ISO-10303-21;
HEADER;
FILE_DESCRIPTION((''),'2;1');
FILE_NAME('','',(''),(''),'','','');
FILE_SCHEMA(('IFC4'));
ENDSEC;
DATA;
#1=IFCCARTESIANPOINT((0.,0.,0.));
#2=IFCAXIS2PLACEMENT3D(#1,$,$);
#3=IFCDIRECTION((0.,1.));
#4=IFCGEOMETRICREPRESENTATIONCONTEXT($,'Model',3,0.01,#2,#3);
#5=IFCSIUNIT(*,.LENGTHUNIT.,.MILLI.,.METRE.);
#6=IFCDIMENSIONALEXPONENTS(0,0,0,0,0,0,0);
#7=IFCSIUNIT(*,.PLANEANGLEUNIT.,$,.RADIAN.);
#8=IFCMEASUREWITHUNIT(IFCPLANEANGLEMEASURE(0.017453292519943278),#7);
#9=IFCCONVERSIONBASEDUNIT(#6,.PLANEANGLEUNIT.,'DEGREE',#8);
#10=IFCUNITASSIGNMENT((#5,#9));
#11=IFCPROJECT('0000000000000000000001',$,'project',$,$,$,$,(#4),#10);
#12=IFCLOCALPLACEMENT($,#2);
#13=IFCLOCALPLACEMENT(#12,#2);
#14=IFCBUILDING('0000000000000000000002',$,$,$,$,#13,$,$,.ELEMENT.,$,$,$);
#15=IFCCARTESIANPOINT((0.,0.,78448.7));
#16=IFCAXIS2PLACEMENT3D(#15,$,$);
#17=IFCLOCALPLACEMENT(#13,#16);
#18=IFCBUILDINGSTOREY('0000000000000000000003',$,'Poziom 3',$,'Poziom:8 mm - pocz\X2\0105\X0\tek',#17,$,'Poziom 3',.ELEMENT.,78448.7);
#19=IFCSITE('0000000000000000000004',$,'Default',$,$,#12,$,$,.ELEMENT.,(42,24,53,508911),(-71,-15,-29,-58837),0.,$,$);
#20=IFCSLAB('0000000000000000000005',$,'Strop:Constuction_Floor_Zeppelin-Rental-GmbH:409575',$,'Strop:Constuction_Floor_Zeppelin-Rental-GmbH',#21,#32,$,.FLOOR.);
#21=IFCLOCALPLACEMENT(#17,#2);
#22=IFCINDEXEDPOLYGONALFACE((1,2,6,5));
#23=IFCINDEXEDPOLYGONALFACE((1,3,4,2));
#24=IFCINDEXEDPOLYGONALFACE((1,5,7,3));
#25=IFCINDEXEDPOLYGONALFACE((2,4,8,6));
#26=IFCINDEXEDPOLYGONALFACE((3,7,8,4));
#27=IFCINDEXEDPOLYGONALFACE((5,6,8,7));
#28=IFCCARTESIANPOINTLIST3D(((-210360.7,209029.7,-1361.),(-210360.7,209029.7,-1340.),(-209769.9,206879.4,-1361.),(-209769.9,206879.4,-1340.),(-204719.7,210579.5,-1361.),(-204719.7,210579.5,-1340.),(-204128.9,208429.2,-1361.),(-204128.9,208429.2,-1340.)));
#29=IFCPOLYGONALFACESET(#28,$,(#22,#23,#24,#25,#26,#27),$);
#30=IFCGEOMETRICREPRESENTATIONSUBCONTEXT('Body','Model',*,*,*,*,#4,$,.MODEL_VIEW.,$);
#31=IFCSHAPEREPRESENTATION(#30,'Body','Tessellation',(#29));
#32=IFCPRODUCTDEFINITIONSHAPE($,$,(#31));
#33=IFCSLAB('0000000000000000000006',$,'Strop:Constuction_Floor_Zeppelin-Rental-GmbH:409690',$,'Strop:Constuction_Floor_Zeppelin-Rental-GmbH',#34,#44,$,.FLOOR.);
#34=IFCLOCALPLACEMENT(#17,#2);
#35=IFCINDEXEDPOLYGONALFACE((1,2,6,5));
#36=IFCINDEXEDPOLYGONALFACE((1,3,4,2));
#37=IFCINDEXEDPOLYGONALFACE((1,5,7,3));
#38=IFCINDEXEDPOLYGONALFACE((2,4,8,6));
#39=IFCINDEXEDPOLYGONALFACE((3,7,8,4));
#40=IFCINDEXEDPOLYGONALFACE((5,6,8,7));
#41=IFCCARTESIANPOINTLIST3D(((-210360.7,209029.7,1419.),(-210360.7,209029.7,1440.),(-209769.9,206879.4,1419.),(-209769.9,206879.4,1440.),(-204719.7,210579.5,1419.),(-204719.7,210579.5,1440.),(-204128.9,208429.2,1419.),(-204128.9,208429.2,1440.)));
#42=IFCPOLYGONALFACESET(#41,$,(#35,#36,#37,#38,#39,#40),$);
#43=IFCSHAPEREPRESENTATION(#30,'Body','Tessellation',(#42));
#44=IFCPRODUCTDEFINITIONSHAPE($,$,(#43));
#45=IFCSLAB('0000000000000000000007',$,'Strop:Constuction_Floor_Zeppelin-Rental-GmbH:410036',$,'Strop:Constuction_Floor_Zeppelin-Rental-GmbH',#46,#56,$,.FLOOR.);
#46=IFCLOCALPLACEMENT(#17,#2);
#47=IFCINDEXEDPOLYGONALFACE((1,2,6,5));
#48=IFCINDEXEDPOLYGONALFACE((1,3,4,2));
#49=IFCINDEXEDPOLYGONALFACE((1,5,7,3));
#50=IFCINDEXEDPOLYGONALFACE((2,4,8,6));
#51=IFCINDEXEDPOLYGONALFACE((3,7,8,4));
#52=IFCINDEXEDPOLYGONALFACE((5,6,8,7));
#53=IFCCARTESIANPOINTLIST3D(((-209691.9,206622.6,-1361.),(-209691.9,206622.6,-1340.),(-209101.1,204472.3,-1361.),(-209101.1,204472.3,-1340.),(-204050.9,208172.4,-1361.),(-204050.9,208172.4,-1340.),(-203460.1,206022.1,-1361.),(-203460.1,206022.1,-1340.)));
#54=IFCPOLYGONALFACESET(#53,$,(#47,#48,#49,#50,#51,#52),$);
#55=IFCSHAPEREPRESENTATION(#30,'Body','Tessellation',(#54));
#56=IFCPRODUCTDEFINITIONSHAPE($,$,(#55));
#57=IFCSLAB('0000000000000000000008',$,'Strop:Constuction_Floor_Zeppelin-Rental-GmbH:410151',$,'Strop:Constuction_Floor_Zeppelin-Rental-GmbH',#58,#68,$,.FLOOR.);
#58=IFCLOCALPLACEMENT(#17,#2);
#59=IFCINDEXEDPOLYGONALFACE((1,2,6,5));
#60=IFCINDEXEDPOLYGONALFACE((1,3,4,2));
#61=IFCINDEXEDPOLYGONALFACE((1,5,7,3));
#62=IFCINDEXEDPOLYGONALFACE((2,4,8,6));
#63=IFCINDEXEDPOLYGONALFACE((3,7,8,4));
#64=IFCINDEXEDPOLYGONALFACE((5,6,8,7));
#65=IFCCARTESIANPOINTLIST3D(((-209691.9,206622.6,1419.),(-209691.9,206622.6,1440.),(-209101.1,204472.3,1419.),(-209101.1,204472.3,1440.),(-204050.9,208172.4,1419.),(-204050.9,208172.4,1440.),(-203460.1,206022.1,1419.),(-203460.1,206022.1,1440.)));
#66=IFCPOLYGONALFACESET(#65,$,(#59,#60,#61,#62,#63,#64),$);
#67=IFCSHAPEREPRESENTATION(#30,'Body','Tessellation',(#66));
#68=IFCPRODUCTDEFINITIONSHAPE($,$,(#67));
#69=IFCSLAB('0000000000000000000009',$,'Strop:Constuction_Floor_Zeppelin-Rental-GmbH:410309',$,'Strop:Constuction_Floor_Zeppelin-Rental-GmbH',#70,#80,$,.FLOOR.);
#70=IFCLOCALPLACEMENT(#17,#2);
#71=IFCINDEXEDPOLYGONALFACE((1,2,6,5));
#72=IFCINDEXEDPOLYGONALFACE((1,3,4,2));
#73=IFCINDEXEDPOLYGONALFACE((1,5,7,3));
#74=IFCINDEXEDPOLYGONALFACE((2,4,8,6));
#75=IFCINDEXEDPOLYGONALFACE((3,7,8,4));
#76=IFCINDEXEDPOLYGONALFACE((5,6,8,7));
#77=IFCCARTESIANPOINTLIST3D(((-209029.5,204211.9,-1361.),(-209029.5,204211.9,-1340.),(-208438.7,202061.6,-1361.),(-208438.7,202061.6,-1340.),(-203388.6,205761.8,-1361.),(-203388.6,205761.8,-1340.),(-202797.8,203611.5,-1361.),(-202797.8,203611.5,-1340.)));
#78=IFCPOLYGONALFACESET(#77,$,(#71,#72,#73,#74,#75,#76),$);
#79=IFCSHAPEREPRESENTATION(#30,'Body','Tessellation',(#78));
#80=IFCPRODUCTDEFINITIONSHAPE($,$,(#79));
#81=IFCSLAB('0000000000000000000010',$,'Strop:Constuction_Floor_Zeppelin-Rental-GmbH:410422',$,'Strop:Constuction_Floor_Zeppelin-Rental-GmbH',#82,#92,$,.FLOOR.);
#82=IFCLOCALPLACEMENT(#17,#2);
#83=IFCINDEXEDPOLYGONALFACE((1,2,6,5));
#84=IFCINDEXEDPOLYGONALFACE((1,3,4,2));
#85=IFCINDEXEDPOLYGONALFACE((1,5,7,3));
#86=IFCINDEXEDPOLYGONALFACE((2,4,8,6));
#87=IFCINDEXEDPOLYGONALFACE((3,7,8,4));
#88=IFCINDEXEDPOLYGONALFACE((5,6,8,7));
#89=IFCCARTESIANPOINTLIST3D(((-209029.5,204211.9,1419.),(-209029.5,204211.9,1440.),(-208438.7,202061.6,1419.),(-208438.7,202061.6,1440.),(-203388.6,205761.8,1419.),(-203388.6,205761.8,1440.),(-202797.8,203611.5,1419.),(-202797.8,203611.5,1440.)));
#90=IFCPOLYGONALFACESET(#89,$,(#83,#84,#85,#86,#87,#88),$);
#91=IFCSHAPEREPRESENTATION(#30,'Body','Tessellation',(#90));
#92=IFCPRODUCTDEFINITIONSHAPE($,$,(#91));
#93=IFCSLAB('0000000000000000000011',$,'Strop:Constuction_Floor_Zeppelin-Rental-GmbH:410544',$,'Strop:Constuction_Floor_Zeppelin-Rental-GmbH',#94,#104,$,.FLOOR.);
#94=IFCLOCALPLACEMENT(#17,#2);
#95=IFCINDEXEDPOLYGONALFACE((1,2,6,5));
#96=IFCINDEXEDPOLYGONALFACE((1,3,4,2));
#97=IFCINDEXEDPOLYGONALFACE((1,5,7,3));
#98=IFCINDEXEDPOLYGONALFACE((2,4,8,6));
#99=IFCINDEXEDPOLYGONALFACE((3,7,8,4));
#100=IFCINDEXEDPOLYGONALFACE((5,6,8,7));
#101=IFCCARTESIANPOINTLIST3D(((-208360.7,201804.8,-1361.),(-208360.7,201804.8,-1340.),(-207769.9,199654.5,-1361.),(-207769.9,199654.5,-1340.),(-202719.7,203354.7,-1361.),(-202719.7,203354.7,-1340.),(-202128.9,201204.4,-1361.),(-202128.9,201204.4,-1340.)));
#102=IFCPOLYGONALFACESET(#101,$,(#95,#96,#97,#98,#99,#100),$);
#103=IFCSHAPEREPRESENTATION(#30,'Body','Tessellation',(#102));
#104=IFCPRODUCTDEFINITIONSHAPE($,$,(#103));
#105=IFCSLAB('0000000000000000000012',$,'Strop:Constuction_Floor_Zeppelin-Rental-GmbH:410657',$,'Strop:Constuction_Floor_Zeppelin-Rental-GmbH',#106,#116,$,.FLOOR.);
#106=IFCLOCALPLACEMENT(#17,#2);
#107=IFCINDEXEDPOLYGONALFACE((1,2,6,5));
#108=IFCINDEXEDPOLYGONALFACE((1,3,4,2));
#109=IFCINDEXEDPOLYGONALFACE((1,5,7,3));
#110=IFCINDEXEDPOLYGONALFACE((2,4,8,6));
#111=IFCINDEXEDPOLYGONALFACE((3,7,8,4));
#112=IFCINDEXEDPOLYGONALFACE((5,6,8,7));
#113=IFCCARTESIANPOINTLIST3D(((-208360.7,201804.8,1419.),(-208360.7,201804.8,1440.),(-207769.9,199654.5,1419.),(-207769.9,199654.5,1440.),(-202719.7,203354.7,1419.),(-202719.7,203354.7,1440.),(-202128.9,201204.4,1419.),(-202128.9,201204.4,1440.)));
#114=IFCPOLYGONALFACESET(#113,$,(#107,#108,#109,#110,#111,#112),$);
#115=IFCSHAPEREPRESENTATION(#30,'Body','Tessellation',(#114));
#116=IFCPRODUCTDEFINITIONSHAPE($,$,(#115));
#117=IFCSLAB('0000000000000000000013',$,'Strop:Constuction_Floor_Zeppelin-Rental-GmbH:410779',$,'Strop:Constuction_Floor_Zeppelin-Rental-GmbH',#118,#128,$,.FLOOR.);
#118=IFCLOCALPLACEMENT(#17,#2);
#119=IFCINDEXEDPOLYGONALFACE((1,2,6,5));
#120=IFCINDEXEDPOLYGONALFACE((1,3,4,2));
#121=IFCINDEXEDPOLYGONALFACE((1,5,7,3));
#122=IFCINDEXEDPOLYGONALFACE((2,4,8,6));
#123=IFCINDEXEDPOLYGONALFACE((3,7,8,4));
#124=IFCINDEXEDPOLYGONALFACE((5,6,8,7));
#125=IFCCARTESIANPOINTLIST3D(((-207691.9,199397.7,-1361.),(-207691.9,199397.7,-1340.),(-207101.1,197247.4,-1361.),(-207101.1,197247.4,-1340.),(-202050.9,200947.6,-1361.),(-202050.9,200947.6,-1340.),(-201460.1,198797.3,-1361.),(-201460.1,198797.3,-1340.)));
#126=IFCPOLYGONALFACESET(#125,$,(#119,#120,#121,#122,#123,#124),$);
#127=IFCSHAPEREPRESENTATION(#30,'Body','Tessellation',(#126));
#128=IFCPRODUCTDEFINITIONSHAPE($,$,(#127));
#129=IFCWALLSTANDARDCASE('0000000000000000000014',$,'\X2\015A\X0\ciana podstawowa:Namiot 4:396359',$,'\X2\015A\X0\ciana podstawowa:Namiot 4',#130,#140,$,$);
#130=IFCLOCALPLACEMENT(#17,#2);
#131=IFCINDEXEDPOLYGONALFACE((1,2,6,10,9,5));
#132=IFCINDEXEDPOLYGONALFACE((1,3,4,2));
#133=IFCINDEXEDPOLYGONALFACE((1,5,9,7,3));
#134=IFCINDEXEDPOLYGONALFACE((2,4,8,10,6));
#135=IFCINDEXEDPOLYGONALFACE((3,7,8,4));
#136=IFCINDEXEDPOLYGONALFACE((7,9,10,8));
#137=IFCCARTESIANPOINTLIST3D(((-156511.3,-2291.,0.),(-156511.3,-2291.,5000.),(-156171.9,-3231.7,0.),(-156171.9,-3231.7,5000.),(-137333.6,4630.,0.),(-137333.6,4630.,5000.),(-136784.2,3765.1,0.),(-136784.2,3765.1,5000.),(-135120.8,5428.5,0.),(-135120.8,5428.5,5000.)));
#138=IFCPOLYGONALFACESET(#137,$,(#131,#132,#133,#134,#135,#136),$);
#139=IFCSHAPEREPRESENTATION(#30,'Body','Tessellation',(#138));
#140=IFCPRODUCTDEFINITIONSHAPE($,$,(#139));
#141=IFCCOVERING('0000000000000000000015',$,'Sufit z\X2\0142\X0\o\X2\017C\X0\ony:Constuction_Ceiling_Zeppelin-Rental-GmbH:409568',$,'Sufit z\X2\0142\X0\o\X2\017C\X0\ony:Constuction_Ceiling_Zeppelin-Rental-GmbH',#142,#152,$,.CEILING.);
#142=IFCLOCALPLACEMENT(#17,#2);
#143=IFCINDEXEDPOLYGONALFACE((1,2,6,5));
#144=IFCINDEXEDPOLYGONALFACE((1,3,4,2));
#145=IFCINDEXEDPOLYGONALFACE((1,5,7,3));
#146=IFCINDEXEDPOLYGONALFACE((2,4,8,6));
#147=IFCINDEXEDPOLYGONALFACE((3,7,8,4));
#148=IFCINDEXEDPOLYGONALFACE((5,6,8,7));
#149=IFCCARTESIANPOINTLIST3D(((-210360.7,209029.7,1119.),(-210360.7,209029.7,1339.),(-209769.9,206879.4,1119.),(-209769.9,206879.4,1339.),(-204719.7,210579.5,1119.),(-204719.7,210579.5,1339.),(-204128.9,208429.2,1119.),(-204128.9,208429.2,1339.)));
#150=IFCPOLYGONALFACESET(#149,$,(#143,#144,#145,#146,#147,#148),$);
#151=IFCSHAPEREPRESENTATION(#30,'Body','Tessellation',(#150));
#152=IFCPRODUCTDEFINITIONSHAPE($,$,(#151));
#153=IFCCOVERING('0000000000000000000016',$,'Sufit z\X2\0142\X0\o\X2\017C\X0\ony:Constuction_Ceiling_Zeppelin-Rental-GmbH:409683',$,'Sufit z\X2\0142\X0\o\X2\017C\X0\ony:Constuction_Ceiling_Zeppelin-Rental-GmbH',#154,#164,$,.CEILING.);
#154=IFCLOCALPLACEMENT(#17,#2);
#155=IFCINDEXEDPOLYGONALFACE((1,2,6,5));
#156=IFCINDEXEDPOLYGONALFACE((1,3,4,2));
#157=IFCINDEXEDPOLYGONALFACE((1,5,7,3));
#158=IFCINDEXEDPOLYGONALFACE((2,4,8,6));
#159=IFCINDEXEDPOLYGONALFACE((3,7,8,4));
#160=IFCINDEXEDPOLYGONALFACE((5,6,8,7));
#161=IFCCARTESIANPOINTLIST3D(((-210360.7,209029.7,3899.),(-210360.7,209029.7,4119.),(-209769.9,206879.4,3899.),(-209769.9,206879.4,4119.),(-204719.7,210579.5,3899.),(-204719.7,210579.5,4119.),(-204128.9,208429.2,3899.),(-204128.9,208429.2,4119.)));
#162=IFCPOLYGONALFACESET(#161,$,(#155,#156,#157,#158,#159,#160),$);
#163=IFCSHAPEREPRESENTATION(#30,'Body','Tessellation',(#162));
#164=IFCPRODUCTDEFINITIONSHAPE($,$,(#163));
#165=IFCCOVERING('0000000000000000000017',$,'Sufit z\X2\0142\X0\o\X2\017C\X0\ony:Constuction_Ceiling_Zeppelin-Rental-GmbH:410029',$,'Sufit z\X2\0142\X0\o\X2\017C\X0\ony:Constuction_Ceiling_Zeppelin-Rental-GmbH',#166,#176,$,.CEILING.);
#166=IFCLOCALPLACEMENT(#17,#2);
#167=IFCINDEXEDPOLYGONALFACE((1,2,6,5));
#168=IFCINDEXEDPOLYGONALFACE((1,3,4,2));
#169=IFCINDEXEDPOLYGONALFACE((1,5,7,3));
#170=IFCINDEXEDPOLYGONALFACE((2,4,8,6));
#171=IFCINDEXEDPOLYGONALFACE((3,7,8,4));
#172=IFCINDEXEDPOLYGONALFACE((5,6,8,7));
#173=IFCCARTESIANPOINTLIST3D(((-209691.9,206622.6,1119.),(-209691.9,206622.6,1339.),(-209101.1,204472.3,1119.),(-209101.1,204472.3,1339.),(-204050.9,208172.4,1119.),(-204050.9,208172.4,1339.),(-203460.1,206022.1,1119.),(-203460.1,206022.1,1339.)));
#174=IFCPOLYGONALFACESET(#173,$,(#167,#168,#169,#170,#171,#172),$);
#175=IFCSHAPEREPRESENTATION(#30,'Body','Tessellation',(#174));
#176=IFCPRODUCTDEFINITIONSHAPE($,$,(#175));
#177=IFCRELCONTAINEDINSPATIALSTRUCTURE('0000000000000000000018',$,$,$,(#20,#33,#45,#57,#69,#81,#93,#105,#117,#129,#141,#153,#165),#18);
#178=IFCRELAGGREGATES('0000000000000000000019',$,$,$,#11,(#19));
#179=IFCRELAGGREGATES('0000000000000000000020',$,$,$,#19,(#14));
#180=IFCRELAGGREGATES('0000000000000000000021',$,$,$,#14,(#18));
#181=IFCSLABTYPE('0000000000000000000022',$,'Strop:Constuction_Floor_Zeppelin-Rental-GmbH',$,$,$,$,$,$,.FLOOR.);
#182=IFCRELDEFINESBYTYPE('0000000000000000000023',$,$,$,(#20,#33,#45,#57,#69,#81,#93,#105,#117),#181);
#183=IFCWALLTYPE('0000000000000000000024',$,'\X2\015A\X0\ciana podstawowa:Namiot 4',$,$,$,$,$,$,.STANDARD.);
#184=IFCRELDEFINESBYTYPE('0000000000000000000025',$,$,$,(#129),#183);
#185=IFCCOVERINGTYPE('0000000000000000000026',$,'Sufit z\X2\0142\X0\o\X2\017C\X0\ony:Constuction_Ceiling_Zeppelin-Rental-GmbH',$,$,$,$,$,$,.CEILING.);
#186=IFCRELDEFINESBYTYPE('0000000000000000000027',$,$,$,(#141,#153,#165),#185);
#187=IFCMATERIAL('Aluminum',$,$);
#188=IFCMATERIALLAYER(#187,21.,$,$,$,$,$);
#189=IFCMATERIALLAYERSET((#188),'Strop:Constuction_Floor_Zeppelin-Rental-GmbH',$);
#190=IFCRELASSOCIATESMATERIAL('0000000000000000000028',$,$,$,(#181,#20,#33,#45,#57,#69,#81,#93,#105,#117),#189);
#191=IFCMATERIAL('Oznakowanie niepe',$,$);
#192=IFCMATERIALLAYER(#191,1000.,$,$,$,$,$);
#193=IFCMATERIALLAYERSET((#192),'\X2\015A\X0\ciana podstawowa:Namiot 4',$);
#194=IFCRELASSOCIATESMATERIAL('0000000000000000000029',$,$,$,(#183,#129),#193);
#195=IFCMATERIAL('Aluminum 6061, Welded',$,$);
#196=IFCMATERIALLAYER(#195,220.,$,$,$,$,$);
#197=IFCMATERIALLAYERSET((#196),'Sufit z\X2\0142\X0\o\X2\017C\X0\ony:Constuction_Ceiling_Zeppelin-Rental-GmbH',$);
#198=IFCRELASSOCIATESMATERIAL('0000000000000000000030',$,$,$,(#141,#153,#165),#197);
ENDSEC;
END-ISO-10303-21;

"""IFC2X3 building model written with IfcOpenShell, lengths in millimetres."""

from ifc_helpers import new_model, entity, si_unit, converted_unit, direction, frame, frame_2d, origin, place, context, subcontext, project, spatial, polyline, rectangle, outline, extrude, material, layer, layer_set, layer_usage, type_object, element, save


model = new_model("IFC2X3")

# Units and contexts
model_context = context("Model", 3, precision=0.01, world=origin(), true_north=direction((0.0, 1.0)))
body_context = subcontext(model_context, "Body", "Model", "MODEL_VIEW")
ifc_project = project(units=[si_unit("LENGTHUNIT", "METRE", prefix="MILLI"), converted_unit("PLANEANGLEUNIT", "DEGREE", entity("IfcPlaneAngleMeasure", 0.017453292519943278), si_unit("PLANEANGLEUNIT", "RADIAN"), dimensions=[0, 0, 0, 0, 0, 0, 0])], contexts=[model_context])

# Site, building, storey
site_placement = place(None, origin())
site = spatial("IfcSite", under=ifc_project, at=site_placement, Name="Default", CompositionType="ELEMENT", RefLatitude=(42, 24, 53, 508911), RefLongitude=(-71, -15, -29, -58837), RefElevation=0.0)
building_placement = place(site_placement, origin())
building = spatial("IfcBuilding", under=site, at=building_placement, CompositionType="ELEMENT")
storey_placement = place(building_placement, frame((0.0, 0.0, 78448.7)))
storey = spatial("IfcBuildingStorey", under=building, at=storey_placement, Name="Poziom 3", ObjectType="Poziom:8 mm - początek", LongName="Poziom 3", CompositionType="ELEMENT", Elevation=78448.7)

# Slabs
ifc_material_1 = material(Name="Aluminum")
ifc_layer_1 = layer(ifc_material_1, 21.0)
ifc_layer_set_1 = layer_set([ifc_layer_1], Name="Strop:Constuction_Floor_Zeppelin-Rental-GmbH")
ifc_layer_usage_1 = layer_usage(ifc_layer_set_1, "AXIS3", "POSITIVE", 0.0)
slab_type_1 = type_object("IfcSlabType", Name="Strop:Constuction_Floor_Zeppelin-Rental-GmbH", PredefinedType="FLOOR", material=ifc_layer_set_1)
slab_1_placement = place(storey_placement, origin())
element("IfcSlab", 1, at=slab_1_placement, inside=storey, type_object=slab_type_1, material=ifc_layer_usage_1, Name="Strop:Constuction_Floor_Zeppelin-Rental-GmbH:409575", ObjectType="Strop:Constuction_Floor_Zeppelin-Rental-GmbH", PredefinedType="FLOOR", context=body_context, shape_type="SweptSolid", body=[
    extrude(rectangle(XDim=5850.0, YDim=2230.0, at=frame_2d((0.0, 0.0), x_axis=(1.0, 0.0))), frame((-207244.8, 208729.5, -1340.0), z_axis=(0.0, 0.0, -1.0), x_axis=(0.964267, 0.264931, 0.0)), (0.0, 0.0, 1.0), 21.0),
])
ifc_layer_usage_2 = layer_usage(ifc_layer_set_1, "AXIS3", "POSITIVE", 0.0)
slab_2_placement = place(storey_placement, origin())
element("IfcSlab", 2, at=slab_2_placement, inside=storey, type_object=slab_type_1, material=ifc_layer_usage_2, Name="Strop:Constuction_Floor_Zeppelin-Rental-GmbH:409690", ObjectType="Strop:Constuction_Floor_Zeppelin-Rental-GmbH", PredefinedType="FLOOR", context=body_context, shape_type="SweptSolid", body=[
    extrude(rectangle(XDim=5850.0, YDim=2230.0, at=frame_2d((0.0, 0.0), x_axis=(1.0, 0.0))), frame((-207244.8, 208729.5, 1440.0), z_axis=(0.0, 0.0, -1.0), x_axis=(0.964267, 0.264931, 0.0)), (0.0, 0.0, 1.0), 21.0),
])
ifc_layer_usage_3 = layer_usage(ifc_layer_set_1, "AXIS3", "POSITIVE", 0.0)
slab_3_placement = place(storey_placement, origin())
element("IfcSlab", 3, at=slab_3_placement, inside=storey, type_object=slab_type_1, material=ifc_layer_usage_3, Name="Strop:Constuction_Floor_Zeppelin-Rental-GmbH:410036", ObjectType="Strop:Constuction_Floor_Zeppelin-Rental-GmbH", PredefinedType="FLOOR", context=body_context, shape_type="SweptSolid", body=[
    extrude(rectangle(XDim=5850.0, YDim=2230.0, at=frame_2d((0.0, 0.0), x_axis=(1.0, 0.0))), frame((-206576.0, 206322.4, -1340.0), z_axis=(0.0, 0.0, -1.0), x_axis=(0.964267, 0.264931, 0.0)), (0.0, 0.0, 1.0), 21.0),
])
ifc_layer_usage_4 = layer_usage(ifc_layer_set_1, "AXIS3", "POSITIVE", 0.0)
slab_4_placement = place(storey_placement, origin())
element("IfcSlab", 4, at=slab_4_placement, inside=storey, type_object=slab_type_1, material=ifc_layer_usage_4, Name="Strop:Constuction_Floor_Zeppelin-Rental-GmbH:410151", ObjectType="Strop:Constuction_Floor_Zeppelin-Rental-GmbH", PredefinedType="FLOOR", context=body_context, shape_type="SweptSolid", body=[
    extrude(rectangle(XDim=5850.0, YDim=2230.0, at=frame_2d((0.0, 0.0), x_axis=(1.0, 0.0))), frame((-206576.0, 206322.4, 1440.0), z_axis=(0.0, 0.0, -1.0), x_axis=(0.964267, 0.264931, 0.0)), (0.0, 0.0, 1.0), 21.0),
])
ifc_layer_usage_5 = layer_usage(ifc_layer_set_1, "AXIS3", "POSITIVE", 0.0)
slab_5_placement = place(storey_placement, origin())
element("IfcSlab", 5, at=slab_5_placement, inside=storey, type_object=slab_type_1, material=ifc_layer_usage_5, Name="Strop:Constuction_Floor_Zeppelin-Rental-GmbH:410309", ObjectType="Strop:Constuction_Floor_Zeppelin-Rental-GmbH", PredefinedType="FLOOR", context=body_context, shape_type="SweptSolid", body=[
    extrude(rectangle(XDim=5850.0, YDim=2230.0, at=frame_2d((0.0, 0.0), x_axis=(1.0, 0.0))), frame((-205913.6, 203911.7, -1340.0), z_axis=(0.0, 0.0, -1.0), x_axis=(0.964267, 0.264931, 0.0)), (0.0, 0.0, 1.0), 21.0),
])
ifc_layer_usage_6 = layer_usage(ifc_layer_set_1, "AXIS3", "POSITIVE", 0.0)
slab_6_placement = place(storey_placement, origin())
element("IfcSlab", 6, at=slab_6_placement, inside=storey, type_object=slab_type_1, material=ifc_layer_usage_6, Name="Strop:Constuction_Floor_Zeppelin-Rental-GmbH:410422", ObjectType="Strop:Constuction_Floor_Zeppelin-Rental-GmbH", PredefinedType="FLOOR", context=body_context, shape_type="SweptSolid", body=[
    extrude(rectangle(XDim=5850.0, YDim=2230.0, at=frame_2d((0.0, 0.0), x_axis=(1.0, 0.0))), frame((-205913.6, 203911.7, 1440.0), z_axis=(0.0, 0.0, -1.0), x_axis=(0.964267, 0.264931, 0.0)), (0.0, 0.0, 1.0), 21.0),
])
ifc_layer_usage_7 = layer_usage(ifc_layer_set_1, "AXIS3", "POSITIVE", 0.0)
slab_7_placement = place(storey_placement, origin())
element("IfcSlab", 7, at=slab_7_placement, inside=storey, type_object=slab_type_1, material=ifc_layer_usage_7, Name="Strop:Constuction_Floor_Zeppelin-Rental-GmbH:410544", ObjectType="Strop:Constuction_Floor_Zeppelin-Rental-GmbH", PredefinedType="FLOOR", context=body_context, shape_type="SweptSolid", body=[
    extrude(rectangle(XDim=5850.0, YDim=2230.0, at=frame_2d((0.0, 0.0), x_axis=(1.0, 0.0))), frame((-205244.8, 201504.6, -1340.0), z_axis=(0.0, 0.0, -1.0), x_axis=(0.964267, 0.264931, 0.0)), (0.0, 0.0, 1.0), 21.0),
])
ifc_layer_usage_8 = layer_usage(ifc_layer_set_1, "AXIS3", "POSITIVE", 0.0)
slab_8_placement = place(storey_placement, origin())
element("IfcSlab", 8, at=slab_8_placement, inside=storey, type_object=slab_type_1, material=ifc_layer_usage_8, Name="Strop:Constuction_Floor_Zeppelin-Rental-GmbH:410657", ObjectType="Strop:Constuction_Floor_Zeppelin-Rental-GmbH", PredefinedType="FLOOR", context=body_context, shape_type="SweptSolid", body=[
    extrude(rectangle(XDim=5850.0, YDim=2230.0, at=frame_2d((0.0, 0.0), x_axis=(1.0, 0.0))), frame((-205244.8, 201504.6, 1440.0), z_axis=(0.0, 0.0, -1.0), x_axis=(0.964267, 0.264931, 0.0)), (0.0, 0.0, 1.0), 21.0),
])
ifc_layer_usage_9 = layer_usage(ifc_layer_set_1, "AXIS3", "POSITIVE", 0.0)
slab_9_placement = place(storey_placement, origin())
element("IfcSlab", 9, at=slab_9_placement, inside=storey, type_object=slab_type_1, material=ifc_layer_usage_9, Name="Strop:Constuction_Floor_Zeppelin-Rental-GmbH:410779", ObjectType="Strop:Constuction_Floor_Zeppelin-Rental-GmbH", PredefinedType="FLOOR", context=body_context, shape_type="SweptSolid", body=[
    extrude(rectangle(XDim=5850.0, YDim=2230.0, at=frame_2d((0.0, 0.0), x_axis=(1.0, 0.0))), frame((-204576.0, 199097.5, -1340.0), z_axis=(0.0, 0.0, -1.0), x_axis=(0.964267, 0.264931, 0.0)), (0.0, 0.0, 1.0), 21.0),
])

# Wall
ifc_material_2 = material(Name="Oznakowanie niepe")
ifc_layer_2 = layer(ifc_material_2, 1000.0)
ifc_layer_set_2 = layer_set([ifc_layer_2], Name="Ściana podstawowa:Namiot 4")
ifc_layer_usage_10 = layer_usage(ifc_layer_set_2, "AXIS2", "NEGATIVE", 500.0)
wall_type = type_object("IfcWallType", Name="Ściana podstawowa:Namiot 4", PredefinedType="STANDARD", material=ifc_layer_set_2)
wall_placement = place(storey_placement, frame((-156341.6, -2761.3, 0.0), z_axis=(0.0, 0.0, 1.0), x_axis=(0.940621, 0.339458, 0.0)))
element("IfcWallStandardCase", 10, at=wall_placement, inside=storey, type_object=wall_type, material=ifc_layer_usage_10, Name="Ściana podstawowa:Namiot 4:396359", ObjectType="Ściana podstawowa:Namiot 4", context=body_context, shape_type="SweptSolid", body=[
    extrude(outline(polyline([(20611.6, -500.0), (22740.9, 500.0), (20388.4, 500.0), (0.0, 500.0), (0.0, -500.0), (20611.6, -500.0)])), origin(), (0.0, 0.0, 1.0), 5000.0),
])

# Coverings
ifc_material_3 = material(Name="Aluminum 6061, Welded")
ifc_layer_3 = layer(ifc_material_3, 220.0)
ifc_layer_set_3 = layer_set([ifc_layer_3], Name="Sufit złożony:Constuction_Ceiling_Zeppelin-Rental-GmbH")
ifc_layer_usage_11 = layer_usage(ifc_layer_set_3, "AXIS3", "NEGATIVE", 220.0)
covering_type = type_object("IfcCoveringType", Name="Sufit złożony:Constuction_Ceiling_Zeppelin-Rental-GmbH", PredefinedType="CEILING")
covering_1_placement = place(storey_placement, origin())
element("IfcCovering", 11, at=covering_1_placement, inside=storey, type_object=covering_type, material=ifc_layer_usage_11, Name="Sufit złożony:Constuction_Ceiling_Zeppelin-Rental-GmbH:409568", ObjectType="Sufit złożony:Constuction_Ceiling_Zeppelin-Rental-GmbH", PredefinedType="CEILING", context=body_context, shape_type="SweptSolid", body=[
    extrude(rectangle(XDim=5850.0, YDim=2230.0, at=frame_2d((0.0, 0.0), x_axis=(1.0, 0.0))), frame((-207244.8, 208729.5, 1119.0), z_axis=(0.0, 0.0, 1.0), x_axis=(-0.964267, -0.264931, 0.0)), (0.0, 0.0, 1.0), 220.0),
])
ifc_layer_usage_12 = layer_usage(ifc_layer_set_3, "AXIS3", "NEGATIVE", 220.0)
covering_2_placement = place(storey_placement, origin())
element("IfcCovering", 12, at=covering_2_placement, inside=storey, type_object=covering_type, material=ifc_layer_usage_12, Name="Sufit złożony:Constuction_Ceiling_Zeppelin-Rental-GmbH:409683", ObjectType="Sufit złożony:Constuction_Ceiling_Zeppelin-Rental-GmbH", PredefinedType="CEILING", context=body_context, shape_type="SweptSolid", body=[
    extrude(rectangle(XDim=5850.0, YDim=2230.0, at=frame_2d((0.0, 0.0), x_axis=(1.0, 0.0))), frame((-207244.8, 208729.5, 3899.0), z_axis=(0.0, 0.0, 1.0), x_axis=(-0.964267, -0.264931, 0.0)), (0.0, 0.0, 1.0), 220.0),
])
ifc_layer_usage_13 = layer_usage(ifc_layer_set_3, "AXIS3", "NEGATIVE", 220.0)
covering_3_placement = place(storey_placement, origin())
element("IfcCovering", 13, at=covering_3_placement, inside=storey, type_object=covering_type, material=ifc_layer_usage_13, Name="Sufit złożony:Constuction_Ceiling_Zeppelin-Rental-GmbH:410029", ObjectType="Sufit złożony:Constuction_Ceiling_Zeppelin-Rental-GmbH", PredefinedType="CEILING", context=body_context, shape_type="SweptSolid", body=[
    extrude(rectangle(XDim=5850.0, YDim=2230.0, at=frame_2d((0.0, 0.0), x_axis=(1.0, 0.0))), frame((-206576.0, 206322.4, 1119.0), z_axis=(0.0, 0.0, 1.0), x_axis=(-0.964267, -0.264931, 0.0)), (0.0, 0.0, 1.0), 220.0),
])

save(model, "model.ifc")
